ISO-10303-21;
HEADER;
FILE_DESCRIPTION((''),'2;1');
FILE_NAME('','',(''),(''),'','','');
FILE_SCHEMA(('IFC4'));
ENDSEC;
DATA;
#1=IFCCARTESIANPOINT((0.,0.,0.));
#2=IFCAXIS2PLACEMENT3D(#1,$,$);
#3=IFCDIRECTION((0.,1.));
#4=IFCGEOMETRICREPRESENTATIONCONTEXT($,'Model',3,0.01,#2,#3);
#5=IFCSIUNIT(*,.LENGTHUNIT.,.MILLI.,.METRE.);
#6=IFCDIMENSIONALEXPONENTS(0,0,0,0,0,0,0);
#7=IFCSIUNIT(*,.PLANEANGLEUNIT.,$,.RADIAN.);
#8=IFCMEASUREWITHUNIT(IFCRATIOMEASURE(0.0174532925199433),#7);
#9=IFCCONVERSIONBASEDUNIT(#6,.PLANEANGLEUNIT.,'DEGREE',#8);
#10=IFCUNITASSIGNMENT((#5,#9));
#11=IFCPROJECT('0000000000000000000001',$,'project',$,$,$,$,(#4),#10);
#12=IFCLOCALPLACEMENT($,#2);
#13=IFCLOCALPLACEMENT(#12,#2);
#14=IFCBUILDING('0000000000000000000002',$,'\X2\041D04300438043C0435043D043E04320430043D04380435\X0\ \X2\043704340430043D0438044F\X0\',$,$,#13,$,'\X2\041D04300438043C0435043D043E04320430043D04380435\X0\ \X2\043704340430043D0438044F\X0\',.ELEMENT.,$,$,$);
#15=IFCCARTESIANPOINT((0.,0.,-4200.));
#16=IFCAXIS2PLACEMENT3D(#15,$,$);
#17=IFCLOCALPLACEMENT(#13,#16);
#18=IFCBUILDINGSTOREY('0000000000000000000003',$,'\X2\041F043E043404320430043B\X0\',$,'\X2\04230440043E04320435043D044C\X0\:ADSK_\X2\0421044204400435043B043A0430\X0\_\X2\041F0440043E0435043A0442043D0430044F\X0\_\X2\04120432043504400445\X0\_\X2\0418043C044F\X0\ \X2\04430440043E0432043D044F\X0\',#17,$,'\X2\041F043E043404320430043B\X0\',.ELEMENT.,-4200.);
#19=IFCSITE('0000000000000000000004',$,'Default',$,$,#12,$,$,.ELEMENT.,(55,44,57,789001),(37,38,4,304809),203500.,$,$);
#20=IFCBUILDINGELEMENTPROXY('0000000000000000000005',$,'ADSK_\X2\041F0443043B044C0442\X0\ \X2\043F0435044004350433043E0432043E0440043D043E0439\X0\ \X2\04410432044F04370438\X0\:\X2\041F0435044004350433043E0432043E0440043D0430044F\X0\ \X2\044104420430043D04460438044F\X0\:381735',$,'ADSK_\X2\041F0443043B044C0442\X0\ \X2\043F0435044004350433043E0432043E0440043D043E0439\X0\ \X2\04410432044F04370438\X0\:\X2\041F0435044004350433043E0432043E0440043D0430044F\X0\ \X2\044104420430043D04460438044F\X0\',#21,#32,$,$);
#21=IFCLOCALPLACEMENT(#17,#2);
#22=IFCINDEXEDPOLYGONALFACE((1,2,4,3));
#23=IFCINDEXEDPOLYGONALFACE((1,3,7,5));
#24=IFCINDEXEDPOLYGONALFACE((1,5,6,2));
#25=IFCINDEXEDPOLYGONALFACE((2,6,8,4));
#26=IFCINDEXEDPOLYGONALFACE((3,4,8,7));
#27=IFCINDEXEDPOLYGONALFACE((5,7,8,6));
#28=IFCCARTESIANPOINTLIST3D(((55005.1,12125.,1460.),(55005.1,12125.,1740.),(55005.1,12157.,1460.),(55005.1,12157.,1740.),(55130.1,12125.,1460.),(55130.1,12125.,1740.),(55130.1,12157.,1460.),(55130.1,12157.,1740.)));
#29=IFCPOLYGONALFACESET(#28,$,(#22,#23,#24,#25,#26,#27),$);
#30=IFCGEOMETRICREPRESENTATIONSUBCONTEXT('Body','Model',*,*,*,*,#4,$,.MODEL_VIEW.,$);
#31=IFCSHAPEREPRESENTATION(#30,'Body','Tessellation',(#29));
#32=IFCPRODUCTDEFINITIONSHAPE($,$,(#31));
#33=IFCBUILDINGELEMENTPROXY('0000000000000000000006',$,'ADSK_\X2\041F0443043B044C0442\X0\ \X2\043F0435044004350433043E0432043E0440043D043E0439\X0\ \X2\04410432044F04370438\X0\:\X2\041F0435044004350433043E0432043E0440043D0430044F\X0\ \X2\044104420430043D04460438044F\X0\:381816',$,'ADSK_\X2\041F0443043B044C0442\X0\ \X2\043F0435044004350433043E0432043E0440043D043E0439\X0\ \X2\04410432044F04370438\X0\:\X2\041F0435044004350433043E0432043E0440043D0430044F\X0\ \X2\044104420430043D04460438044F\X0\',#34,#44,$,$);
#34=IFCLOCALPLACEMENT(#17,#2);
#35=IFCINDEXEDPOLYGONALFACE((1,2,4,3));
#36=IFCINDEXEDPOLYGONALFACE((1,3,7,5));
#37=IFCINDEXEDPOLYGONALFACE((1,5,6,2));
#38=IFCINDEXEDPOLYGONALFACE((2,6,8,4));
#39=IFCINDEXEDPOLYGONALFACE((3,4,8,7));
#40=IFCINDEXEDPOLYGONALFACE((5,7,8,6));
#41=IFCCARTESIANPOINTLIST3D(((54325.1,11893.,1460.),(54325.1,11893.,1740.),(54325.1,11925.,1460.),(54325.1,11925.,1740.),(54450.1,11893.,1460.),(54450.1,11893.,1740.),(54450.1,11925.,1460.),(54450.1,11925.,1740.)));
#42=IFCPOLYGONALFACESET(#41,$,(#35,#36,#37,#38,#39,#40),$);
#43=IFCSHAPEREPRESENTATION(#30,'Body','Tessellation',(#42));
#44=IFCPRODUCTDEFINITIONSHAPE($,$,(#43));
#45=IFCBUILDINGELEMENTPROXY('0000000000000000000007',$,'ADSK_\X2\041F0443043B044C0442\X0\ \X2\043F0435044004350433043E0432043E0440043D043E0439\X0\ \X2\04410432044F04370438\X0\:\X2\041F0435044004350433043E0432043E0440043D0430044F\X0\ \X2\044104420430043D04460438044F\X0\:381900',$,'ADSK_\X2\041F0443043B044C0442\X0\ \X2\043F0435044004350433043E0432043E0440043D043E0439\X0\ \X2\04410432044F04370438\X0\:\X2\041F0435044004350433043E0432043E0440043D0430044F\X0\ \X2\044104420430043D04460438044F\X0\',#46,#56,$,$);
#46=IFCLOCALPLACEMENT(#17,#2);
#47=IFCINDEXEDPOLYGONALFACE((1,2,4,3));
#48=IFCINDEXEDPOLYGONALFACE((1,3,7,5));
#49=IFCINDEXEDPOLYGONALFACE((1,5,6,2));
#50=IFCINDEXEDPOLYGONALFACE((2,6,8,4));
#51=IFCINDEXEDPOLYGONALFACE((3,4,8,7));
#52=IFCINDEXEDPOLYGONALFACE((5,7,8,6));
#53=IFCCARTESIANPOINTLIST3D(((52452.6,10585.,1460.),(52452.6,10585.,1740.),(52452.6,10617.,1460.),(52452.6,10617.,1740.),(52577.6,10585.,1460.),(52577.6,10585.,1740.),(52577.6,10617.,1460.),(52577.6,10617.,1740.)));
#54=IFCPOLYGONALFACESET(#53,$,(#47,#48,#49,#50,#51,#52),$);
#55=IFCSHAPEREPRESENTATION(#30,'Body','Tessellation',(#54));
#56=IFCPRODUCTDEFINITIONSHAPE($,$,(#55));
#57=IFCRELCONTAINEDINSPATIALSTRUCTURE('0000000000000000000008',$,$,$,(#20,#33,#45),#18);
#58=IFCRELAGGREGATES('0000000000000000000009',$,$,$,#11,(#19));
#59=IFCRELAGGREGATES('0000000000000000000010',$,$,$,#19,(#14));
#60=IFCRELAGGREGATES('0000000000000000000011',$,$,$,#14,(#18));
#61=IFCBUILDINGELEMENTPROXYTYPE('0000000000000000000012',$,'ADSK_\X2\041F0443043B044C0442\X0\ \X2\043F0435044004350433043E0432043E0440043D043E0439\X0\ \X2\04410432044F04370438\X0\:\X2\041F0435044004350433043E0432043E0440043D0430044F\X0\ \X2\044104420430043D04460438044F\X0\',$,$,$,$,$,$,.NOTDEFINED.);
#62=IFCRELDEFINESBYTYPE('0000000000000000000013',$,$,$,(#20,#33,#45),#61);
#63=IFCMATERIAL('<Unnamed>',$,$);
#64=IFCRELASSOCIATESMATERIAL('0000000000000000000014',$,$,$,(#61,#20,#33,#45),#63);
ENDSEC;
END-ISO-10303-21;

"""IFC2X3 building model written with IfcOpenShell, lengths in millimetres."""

from ifc_helpers import new_model, entity, si_unit, converted_unit, direction, frame, origin, origin_2d_with_axis, place, context, subcontext, project, spatial, rectangle, extrude, source, transform, mapped, material, type_object, type_shapes, element, save


model = new_model("IFC2X3")

# Units and contexts
model_context = context("Model", 3, precision=0.01, world=origin(), true_north=direction((0.0, 1.0)))
body_context = subcontext(model_context, "Body", "Model", "MODEL_VIEW")
ifc_project = project(units=[si_unit("LENGTHUNIT", "METRE", prefix="MILLI"), converted_unit("PLANEANGLEUNIT", "DEGREE", entity("IfcRatioMeasure", 0.0174532925199433), si_unit("PLANEANGLEUNIT", "RADIAN"), dimensions=[0, 0, 0, 0, 0, 0, 0])], contexts=[model_context])

# Site, building, storey
site_placement = place(None, origin())
site = spatial("IfcSite", under=ifc_project, at=site_placement, Name="Default", CompositionType="ELEMENT", RefLatitude=(55, 44, 57, 789001), RefLongitude=(37, 38, 4, 304809), RefElevation=203500.0)
building_placement = place(site_placement, origin())
building = spatial("IfcBuilding", under=site, at=building_placement, Name="Наименование здания", LongName="Наименование здания", CompositionType="ELEMENT")
storey_placement = place(building_placement, frame((0.0, 0.0, -4200.0)))
storey = spatial("IfcBuildingStorey", under=building, at=storey_placement, Name="Подвал", ObjectType="Уровень:ADSK_Стрелка_Проектная_Вверх_Имя уровня", LongName="Подвал", CompositionType="ELEMENT", Elevation=-4200.0)

# Building element proxies
ifc_material = material(Name="<Unnamed>")
building_element_proxy_type = type_object("IfcBuildingElementProxyType", Name="ADSK_Пульт переговорной связи:Переговорная станция", PredefinedType="NOTDEFINED", material=ifc_material)
shared_shape = source(origin(), body_context, "Body", "SweptSolid", [
    extrude(rectangle(XDim=125.0, YDim=32.0, at=origin_2d_with_axis()), frame((0.0, 16.0, -140.0), z_axis=(0.0, 0.0, 1.0), x_axis=(-1.0, 0.0, 0.0)), (0.0, 0.0, 1.0), 280.0),
])
type_shapes(building_element_proxy_type, [shared_shape])
proxy_1_placement = place(storey_placement, frame((55067.6, 12157.0, 1600.0), z_axis=(0.0, 0.0, 1.0), x_axis=(-1.0, 0.0, 0.0)))
element("IfcBuildingElementProxy", 1, at=proxy_1_placement, inside=storey, type_object=building_element_proxy_type, material=ifc_material, Name="ADSK_Пульт переговорной связи:Переговорная станция:381735", ObjectType="ADSK_Пульт переговорной связи:Переговорная станция", context=body_context, shape_type="MappedRepresentation", body=[
    mapped(shared_shape, transform((0.0, 0.0, 0.0), scale=1.0)),
])
proxy_2_placement = place(storey_placement, frame((54387.6, 11893.0, 1600.0)))
element("IfcBuildingElementProxy", 2, at=proxy_2_placement, inside=storey, type_object=building_element_proxy_type, material=ifc_material, Name="ADSK_Пульт переговорной связи:Переговорная станция:381816", ObjectType="ADSK_Пульт переговорной связи:Переговорная станция", context=body_context, shape_type="MappedRepresentation", body=[
    mapped(shared_shape, transform((0.0, 0.0, 0.0), scale=1.0)),
])
proxy_3_placement = place(storey_placement, frame((52515.1, 10617.0, 1600.0), z_axis=(0.0, 0.0, 1.0), x_axis=(-1.0, 0.0, 0.0)))
element("IfcBuildingElementProxy", 3, at=proxy_3_placement, inside=storey, type_object=building_element_proxy_type, material=ifc_material, Name="ADSK_Пульт переговорной связи:Переговорная станция:381900", ObjectType="ADSK_Пульт переговорной связи:Переговорная станция", context=body_context, shape_type="MappedRepresentation", body=[
    mapped(shared_shape, transform((0.0, 0.0, 0.0), scale=1.0)),
])

save(model, "model.ifc")
